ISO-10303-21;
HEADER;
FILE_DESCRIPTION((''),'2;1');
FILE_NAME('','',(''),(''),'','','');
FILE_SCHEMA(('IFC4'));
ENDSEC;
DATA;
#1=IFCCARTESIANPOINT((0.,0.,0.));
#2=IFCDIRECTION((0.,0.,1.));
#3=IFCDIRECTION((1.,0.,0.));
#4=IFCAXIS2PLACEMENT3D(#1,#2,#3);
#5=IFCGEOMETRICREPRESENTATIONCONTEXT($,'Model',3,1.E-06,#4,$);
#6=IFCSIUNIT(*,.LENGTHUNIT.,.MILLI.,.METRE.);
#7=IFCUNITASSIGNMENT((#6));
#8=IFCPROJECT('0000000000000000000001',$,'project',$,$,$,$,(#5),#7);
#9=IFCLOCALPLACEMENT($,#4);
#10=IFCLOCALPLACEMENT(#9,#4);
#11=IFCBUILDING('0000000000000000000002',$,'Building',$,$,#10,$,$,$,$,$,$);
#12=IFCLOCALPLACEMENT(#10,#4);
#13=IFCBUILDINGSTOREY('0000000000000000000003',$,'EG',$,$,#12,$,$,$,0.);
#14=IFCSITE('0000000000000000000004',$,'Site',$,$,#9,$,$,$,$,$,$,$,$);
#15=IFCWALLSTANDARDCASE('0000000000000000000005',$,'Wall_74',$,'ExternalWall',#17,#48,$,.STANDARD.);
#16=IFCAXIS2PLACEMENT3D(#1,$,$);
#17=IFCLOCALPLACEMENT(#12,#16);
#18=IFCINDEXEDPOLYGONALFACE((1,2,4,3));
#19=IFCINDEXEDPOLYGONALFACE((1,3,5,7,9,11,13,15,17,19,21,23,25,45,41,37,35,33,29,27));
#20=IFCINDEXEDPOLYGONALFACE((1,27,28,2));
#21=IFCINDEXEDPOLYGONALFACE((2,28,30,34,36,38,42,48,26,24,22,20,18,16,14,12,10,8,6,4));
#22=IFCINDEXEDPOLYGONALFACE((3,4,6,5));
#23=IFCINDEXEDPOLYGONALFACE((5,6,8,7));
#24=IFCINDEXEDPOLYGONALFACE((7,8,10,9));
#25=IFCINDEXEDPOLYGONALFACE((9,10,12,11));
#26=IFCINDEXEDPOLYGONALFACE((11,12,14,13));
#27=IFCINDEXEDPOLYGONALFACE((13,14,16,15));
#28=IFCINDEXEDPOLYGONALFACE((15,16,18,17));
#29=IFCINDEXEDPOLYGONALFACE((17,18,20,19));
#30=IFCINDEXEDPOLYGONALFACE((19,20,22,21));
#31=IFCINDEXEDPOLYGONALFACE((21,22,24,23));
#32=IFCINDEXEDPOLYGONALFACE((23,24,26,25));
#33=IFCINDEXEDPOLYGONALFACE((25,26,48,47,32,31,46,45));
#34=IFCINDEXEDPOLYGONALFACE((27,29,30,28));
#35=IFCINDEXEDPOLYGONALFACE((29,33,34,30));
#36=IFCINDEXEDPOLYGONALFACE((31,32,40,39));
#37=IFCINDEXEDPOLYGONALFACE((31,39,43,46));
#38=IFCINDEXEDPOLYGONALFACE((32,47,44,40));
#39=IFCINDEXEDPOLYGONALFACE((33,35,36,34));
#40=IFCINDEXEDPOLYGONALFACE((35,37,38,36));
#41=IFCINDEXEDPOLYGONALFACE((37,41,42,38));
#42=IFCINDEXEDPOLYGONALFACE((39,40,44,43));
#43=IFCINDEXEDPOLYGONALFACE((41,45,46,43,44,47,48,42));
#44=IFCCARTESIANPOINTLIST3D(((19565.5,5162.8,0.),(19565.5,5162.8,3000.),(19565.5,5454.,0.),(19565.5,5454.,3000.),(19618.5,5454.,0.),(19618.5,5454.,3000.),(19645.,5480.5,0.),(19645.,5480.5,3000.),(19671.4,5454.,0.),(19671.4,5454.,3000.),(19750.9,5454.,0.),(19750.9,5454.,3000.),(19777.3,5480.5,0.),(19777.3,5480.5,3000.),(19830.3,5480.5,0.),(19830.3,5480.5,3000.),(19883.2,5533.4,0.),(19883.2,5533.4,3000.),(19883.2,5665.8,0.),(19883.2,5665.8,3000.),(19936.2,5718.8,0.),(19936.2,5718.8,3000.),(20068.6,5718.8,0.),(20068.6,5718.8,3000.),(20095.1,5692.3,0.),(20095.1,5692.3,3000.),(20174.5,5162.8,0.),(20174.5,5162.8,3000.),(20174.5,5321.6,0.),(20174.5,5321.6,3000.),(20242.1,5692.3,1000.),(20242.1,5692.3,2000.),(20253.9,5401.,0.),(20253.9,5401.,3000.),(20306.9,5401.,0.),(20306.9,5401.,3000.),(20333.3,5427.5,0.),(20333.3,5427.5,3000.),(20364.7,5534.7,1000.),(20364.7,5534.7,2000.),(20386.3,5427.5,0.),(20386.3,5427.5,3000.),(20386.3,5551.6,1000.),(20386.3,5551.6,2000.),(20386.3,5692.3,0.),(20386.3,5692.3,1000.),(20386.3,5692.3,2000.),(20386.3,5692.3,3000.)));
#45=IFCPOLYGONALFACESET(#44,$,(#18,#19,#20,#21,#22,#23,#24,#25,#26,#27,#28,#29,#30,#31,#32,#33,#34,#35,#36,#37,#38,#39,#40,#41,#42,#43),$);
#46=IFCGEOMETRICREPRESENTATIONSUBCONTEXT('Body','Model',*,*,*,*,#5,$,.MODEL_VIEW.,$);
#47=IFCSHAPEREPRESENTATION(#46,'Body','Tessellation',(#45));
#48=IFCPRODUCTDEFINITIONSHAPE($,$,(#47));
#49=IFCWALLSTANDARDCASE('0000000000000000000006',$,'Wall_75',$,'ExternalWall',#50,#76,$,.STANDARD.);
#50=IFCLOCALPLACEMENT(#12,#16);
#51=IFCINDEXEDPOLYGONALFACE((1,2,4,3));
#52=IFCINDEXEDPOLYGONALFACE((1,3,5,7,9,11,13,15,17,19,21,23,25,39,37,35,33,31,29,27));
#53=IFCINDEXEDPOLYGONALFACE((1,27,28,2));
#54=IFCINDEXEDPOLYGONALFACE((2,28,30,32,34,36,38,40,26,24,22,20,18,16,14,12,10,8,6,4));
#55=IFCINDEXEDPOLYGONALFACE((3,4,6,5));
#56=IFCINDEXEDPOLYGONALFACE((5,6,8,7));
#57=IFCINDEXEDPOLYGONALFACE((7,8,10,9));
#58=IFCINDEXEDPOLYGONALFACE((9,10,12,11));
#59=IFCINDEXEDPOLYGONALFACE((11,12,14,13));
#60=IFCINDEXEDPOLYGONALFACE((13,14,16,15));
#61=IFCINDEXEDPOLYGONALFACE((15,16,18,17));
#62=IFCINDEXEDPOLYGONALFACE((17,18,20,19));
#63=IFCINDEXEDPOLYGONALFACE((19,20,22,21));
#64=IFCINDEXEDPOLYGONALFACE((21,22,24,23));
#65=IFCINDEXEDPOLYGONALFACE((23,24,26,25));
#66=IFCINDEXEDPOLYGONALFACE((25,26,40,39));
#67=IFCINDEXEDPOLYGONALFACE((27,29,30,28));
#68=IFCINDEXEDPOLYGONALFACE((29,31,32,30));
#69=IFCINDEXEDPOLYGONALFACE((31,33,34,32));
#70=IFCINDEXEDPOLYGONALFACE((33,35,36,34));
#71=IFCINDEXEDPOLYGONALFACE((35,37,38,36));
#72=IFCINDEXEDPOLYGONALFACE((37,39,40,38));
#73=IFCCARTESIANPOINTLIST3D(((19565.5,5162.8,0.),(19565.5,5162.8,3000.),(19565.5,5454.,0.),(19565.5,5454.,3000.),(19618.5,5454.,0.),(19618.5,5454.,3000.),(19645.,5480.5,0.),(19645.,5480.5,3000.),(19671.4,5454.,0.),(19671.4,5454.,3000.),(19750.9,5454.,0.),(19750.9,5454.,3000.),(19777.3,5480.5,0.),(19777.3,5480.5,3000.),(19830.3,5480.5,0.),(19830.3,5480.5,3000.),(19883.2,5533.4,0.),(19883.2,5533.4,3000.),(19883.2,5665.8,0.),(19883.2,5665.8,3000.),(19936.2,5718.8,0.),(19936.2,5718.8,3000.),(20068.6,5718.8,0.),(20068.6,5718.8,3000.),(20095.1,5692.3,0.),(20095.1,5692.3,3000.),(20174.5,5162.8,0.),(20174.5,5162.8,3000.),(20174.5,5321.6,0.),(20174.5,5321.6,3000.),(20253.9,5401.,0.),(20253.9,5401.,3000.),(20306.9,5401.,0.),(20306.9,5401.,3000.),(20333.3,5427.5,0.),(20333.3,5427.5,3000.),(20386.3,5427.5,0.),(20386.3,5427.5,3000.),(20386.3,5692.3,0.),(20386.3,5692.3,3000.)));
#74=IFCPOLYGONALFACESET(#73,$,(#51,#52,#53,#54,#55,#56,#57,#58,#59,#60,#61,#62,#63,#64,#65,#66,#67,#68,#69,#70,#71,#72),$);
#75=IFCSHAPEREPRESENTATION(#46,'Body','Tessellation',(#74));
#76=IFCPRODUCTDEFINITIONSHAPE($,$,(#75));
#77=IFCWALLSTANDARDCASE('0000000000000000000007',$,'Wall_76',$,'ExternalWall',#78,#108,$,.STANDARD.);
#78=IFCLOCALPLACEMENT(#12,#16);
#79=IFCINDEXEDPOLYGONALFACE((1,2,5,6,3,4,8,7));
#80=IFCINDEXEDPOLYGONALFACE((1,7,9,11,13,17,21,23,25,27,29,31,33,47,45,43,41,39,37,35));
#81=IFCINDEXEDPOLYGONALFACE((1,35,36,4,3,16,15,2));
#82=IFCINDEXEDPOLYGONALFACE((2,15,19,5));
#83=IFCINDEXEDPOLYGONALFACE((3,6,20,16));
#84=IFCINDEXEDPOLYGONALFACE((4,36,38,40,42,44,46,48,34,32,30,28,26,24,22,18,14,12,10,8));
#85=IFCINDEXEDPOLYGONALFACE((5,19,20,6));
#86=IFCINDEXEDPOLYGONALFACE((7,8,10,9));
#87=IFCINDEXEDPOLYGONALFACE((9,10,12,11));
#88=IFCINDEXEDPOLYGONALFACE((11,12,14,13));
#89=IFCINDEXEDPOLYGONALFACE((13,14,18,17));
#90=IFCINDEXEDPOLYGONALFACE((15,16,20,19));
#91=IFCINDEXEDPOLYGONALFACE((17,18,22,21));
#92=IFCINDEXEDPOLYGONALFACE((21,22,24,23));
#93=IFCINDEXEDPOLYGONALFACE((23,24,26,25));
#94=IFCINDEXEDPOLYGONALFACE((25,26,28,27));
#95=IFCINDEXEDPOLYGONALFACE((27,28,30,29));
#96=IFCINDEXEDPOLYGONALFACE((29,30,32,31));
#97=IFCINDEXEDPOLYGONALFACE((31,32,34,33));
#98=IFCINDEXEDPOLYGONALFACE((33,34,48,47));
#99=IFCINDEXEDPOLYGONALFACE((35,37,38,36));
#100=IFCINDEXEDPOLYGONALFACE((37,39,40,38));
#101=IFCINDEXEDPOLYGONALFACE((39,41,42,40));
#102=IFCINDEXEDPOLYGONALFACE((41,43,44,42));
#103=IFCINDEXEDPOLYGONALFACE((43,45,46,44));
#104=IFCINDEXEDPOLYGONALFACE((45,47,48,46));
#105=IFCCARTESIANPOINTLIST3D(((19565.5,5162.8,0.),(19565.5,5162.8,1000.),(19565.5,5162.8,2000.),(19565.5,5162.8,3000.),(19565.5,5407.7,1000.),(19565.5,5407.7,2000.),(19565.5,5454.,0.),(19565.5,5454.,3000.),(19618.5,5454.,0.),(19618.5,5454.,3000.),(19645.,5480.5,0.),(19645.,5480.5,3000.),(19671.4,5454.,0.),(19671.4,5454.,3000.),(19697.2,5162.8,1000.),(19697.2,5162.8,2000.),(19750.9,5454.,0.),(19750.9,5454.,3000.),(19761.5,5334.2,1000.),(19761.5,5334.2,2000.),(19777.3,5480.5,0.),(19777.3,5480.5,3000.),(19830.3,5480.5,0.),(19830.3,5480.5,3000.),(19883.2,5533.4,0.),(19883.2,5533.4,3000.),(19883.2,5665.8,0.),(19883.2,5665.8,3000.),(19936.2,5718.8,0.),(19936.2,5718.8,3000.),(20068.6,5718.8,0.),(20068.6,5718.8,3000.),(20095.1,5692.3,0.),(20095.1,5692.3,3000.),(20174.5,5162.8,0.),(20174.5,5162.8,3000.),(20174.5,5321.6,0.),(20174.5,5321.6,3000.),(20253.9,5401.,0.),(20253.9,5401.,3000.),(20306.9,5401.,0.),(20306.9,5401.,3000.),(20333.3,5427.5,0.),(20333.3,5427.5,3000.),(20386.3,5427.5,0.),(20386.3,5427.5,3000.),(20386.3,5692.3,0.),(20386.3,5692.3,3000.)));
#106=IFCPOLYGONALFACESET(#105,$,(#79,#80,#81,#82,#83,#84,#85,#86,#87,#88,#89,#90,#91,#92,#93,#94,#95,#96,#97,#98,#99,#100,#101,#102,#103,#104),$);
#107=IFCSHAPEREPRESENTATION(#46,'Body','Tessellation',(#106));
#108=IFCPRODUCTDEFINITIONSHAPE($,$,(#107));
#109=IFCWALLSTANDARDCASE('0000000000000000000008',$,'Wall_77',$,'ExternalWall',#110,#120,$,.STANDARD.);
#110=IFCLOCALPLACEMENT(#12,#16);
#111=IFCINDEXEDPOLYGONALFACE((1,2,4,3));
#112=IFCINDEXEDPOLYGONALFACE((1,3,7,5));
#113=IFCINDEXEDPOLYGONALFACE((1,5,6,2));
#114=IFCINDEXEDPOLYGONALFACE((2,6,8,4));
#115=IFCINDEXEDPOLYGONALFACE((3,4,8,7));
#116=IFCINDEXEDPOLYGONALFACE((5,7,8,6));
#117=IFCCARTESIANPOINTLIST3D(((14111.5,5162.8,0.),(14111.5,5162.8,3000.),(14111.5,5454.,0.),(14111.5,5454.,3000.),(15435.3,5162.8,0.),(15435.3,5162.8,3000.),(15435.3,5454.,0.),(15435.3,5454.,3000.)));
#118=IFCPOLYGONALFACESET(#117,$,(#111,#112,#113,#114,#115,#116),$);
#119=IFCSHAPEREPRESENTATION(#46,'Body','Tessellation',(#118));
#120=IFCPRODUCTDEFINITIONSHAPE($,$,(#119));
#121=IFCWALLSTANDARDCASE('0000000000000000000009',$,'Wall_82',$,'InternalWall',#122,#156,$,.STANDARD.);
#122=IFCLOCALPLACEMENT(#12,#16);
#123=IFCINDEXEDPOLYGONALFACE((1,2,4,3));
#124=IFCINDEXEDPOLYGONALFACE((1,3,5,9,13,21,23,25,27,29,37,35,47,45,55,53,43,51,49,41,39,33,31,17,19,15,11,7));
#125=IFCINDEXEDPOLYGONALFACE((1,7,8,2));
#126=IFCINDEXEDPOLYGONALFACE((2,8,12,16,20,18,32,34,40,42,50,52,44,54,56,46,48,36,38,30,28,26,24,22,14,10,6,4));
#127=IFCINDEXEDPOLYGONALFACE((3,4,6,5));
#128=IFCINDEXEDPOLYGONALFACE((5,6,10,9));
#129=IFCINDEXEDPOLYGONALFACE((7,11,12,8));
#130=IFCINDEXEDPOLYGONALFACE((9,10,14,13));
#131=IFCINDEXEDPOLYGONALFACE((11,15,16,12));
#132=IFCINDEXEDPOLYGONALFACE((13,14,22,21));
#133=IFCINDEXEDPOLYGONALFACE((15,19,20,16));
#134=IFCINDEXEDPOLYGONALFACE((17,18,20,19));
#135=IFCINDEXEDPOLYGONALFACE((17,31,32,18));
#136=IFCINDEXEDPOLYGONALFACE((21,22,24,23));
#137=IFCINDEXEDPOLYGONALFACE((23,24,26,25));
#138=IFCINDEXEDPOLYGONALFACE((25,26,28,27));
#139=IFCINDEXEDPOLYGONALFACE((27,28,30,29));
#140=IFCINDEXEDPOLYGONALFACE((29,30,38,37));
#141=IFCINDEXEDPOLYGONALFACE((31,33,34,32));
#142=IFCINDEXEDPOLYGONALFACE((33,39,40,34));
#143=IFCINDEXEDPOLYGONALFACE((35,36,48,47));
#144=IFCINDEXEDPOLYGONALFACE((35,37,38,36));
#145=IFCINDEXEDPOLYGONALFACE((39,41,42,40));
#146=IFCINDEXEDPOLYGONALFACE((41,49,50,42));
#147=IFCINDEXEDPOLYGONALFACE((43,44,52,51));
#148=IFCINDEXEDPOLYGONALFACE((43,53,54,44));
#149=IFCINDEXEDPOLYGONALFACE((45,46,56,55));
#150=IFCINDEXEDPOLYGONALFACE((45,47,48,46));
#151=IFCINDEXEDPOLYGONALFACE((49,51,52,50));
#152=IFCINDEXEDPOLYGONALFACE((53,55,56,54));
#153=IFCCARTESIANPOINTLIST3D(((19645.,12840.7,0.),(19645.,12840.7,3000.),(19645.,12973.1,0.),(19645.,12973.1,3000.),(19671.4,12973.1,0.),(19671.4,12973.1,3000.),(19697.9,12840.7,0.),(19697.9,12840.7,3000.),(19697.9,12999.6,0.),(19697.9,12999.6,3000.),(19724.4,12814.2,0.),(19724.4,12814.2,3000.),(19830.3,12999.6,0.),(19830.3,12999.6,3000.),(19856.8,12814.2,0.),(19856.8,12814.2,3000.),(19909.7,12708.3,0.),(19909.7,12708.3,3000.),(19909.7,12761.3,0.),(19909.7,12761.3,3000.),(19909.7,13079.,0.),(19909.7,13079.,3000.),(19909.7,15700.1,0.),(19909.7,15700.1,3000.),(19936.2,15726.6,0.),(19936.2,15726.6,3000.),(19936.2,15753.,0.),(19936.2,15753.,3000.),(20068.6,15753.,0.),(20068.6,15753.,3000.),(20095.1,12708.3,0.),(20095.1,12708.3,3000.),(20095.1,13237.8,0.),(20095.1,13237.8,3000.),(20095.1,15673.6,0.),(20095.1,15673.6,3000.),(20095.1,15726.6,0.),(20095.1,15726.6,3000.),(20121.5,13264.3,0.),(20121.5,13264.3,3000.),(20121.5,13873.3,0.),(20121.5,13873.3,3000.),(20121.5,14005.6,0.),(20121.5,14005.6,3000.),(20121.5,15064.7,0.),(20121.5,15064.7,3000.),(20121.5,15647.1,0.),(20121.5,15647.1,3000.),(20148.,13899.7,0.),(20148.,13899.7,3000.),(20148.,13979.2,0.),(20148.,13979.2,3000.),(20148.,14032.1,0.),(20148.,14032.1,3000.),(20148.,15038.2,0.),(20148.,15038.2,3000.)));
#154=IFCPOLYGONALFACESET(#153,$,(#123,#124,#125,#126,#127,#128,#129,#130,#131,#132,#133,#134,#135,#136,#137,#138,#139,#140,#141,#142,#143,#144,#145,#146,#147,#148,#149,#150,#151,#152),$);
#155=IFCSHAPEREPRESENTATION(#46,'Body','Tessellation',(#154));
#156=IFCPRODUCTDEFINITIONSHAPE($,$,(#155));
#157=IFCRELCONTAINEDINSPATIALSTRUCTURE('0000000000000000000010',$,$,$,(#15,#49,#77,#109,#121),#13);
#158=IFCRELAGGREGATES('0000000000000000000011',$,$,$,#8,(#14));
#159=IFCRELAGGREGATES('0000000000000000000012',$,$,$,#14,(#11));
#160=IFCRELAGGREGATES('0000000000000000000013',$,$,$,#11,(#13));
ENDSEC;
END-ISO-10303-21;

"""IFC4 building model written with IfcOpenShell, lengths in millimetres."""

from ifc_helpers import new_model, si_unit, frame, origin_with_axes, place, context, subcontext, project, spatial, polyline, rectangle, outline, extrude, element, save


model = new_model("IFC4")

# Units and contexts
model_context = context("Model", 3, precision=1e-06, world=origin_with_axes())
body_context = subcontext(model_context, "Body", "Model", "MODEL_VIEW")
ifc_project = project(units=[si_unit("LENGTHUNIT", "METRE", prefix="MILLI")], contexts=[model_context])

# Site, building, storey
site_placement = place(None, origin_with_axes())
site = spatial("IfcSite", under=ifc_project, at=site_placement, Name="Site")
building_placement = place(site_placement, origin_with_axes())
building = spatial("IfcBuilding", under=site, at=building_placement, Name="Building")
storey_placement = place(building_placement, origin_with_axes())
storey = spatial("IfcBuildingStorey", under=building, at=storey_placement, Name="EG", Elevation=0.0)

# Wall, opening
wall_1_placement = place(storey_placement, origin_with_axes())
wall_1 = element("IfcWallStandardCase", 1, at=wall_1_placement, inside=storey, Name="Wall_74", ObjectType="ExternalWall", PredefinedType="STANDARD", context=body_context, shape_type="SweptSolid", body=[
    extrude(outline(polyline([(19565.5, 5162.8, 0.0), (19565.5, 5454.0, 0.0), (19618.5, 5454.0, 0.0), (19645.0, 5480.5, 0.0), (19671.4, 5454.0, 0.0), (19750.9, 5454.0, 0.0), (19777.3, 5480.5, 0.0), (19830.3, 5480.5, 0.0), (19883.2, 5533.4, 0.0), (19883.2, 5665.8, 0.0), (19936.2, 5718.8, 0.0), (20068.6, 5718.8, 0.0), (20095.1, 5692.3, 0.0), (20386.3, 5692.3, 0.0), (20386.3, 5427.5, 0.0), (20333.3, 5427.5, 0.0), (20306.9, 5401.0, 0.0), (20253.9, 5401.0, 0.0), (20174.5, 5321.6, 0.0), (20174.5, 5162.8, 0.0), (19565.5, 5162.8, 0.0)])), origin_with_axes(), (0.0, 0.0, 1.0), 3000.0),
])
opening_1_placement = place(wall_1_placement, origin_with_axes())
element("IfcOpeningElement", 2, at=opening_1_placement, inside=storey, cuts=wall_1, context=body_context, shape_type="SweptSolid", body=[
    extrude(rectangle(XDim=2956.0, YDim=240.0), frame((21457.7, 6536.9, 1000.0), z_axis=(0.0, 0.0, 1.0), x_axis=(-0.789352, -0.613941, 0.0)), (0.0, 0.0, 1.0), 1000.0),
])

# Wall
wall_2_placement = place(storey_placement, origin_with_axes())
element("IfcWallStandardCase", 3, at=wall_2_placement, inside=storey, Name="Wall_75", ObjectType="ExternalWall", PredefinedType="STANDARD", context=body_context, shape_type="SweptSolid", body=[
    extrude(outline(polyline([(19565.5, 5162.8, 0.0), (19565.5, 5454.0, 0.0), (19618.5, 5454.0, 0.0), (19645.0, 5480.5, 0.0), (19671.4, 5454.0, 0.0), (19750.9, 5454.0, 0.0), (19777.3, 5480.5, 0.0), (19830.3, 5480.5, 0.0), (19883.2, 5533.4, 0.0), (19883.2, 5665.8, 0.0), (19936.2, 5718.8, 0.0), (20068.6, 5718.8, 0.0), (20095.1, 5692.3, 0.0), (20386.3, 5692.3, 0.0), (20386.3, 5427.5, 0.0), (20333.3, 5427.5, 0.0), (20306.9, 5401.0, 0.0), (20253.9, 5401.0, 0.0), (20174.5, 5321.6, 0.0), (20174.5, 5162.8, 0.0), (19565.5, 5162.8, 0.0)])), origin_with_axes(), (0.0, 0.0, 1.0), 3000.0),
])

# Wall, opening
wall_3_placement = place(storey_placement, origin_with_axes())
wall_3 = element("IfcWallStandardCase", 4, at=wall_3_placement, inside=storey, Name="Wall_76", ObjectType="ExternalWall", PredefinedType="STANDARD", context=body_context, shape_type="SweptSolid", body=[
    extrude(outline(polyline([(19565.5, 5162.8, 0.0), (19565.5, 5454.0, 0.0), (19618.5, 5454.0, 0.0), (19645.0, 5480.5, 0.0), (19671.4, 5454.0, 0.0), (19750.9, 5454.0, 0.0), (19777.3, 5480.5, 0.0), (19830.3, 5480.5, 0.0), (19883.2, 5533.4, 0.0), (19883.2, 5665.8, 0.0), (19936.2, 5718.8, 0.0), (20068.6, 5718.8, 0.0), (20095.1, 5692.3, 0.0), (20386.3, 5692.3, 0.0), (20386.3, 5427.5, 0.0), (20333.3, 5427.5, 0.0), (20306.9, 5401.0, 0.0), (20253.9, 5401.0, 0.0), (20174.5, 5321.6, 0.0), (20174.5, 5162.8, 0.0), (19565.5, 5162.8, 0.0)])), origin_with_axes(), (0.0, 0.0, 1.0), 3000.0),
])
opening_2_placement = place(wall_3_placement, origin_with_axes())
element("IfcOpeningElement", 5, at=opening_2_placement, inside=storey, cuts=wall_3, context=body_context, shape_type="SweptSolid", body=[
    extrude(rectangle(XDim=694.1, YDim=240.0), frame((19527.2, 5051.4, 1000.0), z_axis=(0.0, 0.0, 1.0), x_axis=(0.351123, 0.936329, 0.0)), (0.0, 0.0, 1.0), 1000.0),
])

# Walls
for number, where, z_axis, x_axis, name in (
    (6, (0.0, 0.0, 0.0), (0.0, 0.0, 1.0), (1.0, 0.0, 0.0), "Wall_77"),
):
    element("IfcWallStandardCase", number, at=place(storey_placement, frame(where, z_axis=z_axis, x_axis=x_axis)), inside=storey, Name=name, ObjectType="ExternalWall", PredefinedType="STANDARD", context=body_context, shape_type="SweptSolid", body=[
        extrude(outline(polyline([(14111.5, 5162.8, 0.0), (14111.5, 5454.0, 0.0), (15435.3, 5454.0, 0.0), (15435.3, 5162.8, 0.0), (14111.5, 5162.8, 0.0)])), origin_with_axes(), (0.0, 0.0, 1.0), 3000.0),
    ])
wall_4_placement = place(storey_placement, origin_with_axes())
element("IfcWallStandardCase", 7, at=wall_4_placement, inside=storey, Name="Wall_82", ObjectType="InternalWall", PredefinedType="STANDARD", context=body_context, shape_type="SweptSolid", body=[
    extrude(outline(polyline([(19909.7, 12708.3, 0.0), (19909.7, 12761.3, 0.0), (19856.8, 12814.2, 0.0), (19724.4, 12814.2, 0.0), (19697.9, 12840.7, 0.0), (19645.0, 12840.7, 0.0), (19645.0, 12973.1, 0.0), (19671.4, 12973.1, 0.0), (19697.9, 12999.6, 0.0), (19830.3, 12999.6, 0.0), (19909.7, 13079.0, 0.0), (19909.7, 15700.1, 0.0), (19936.2, 15726.6, 0.0), (19936.2, 15753.0, 0.0), (20068.6, 15753.0, 0.0), (20095.1, 15726.6, 0.0), (20095.1, 15673.6, 0.0), (20121.5, 15647.1, 0.0), (20121.5, 15064.7, 0.0), (20148.0, 15038.2, 0.0), (20148.0, 14032.1, 0.0), (20121.5, 14005.6, 0.0), (20148.0, 13979.2, 0.0), (20148.0, 13899.7, 0.0), (20121.5, 13873.3, 0.0), (20121.5, 13264.3, 0.0), (20095.1, 13237.8, 0.0), (20095.1, 12708.3, 0.0), (19909.7, 12708.3, 0.0)])), origin_with_axes(), (0.0, 0.0, 1.0), 3000.0),
])

save(model, "model.ifc")
